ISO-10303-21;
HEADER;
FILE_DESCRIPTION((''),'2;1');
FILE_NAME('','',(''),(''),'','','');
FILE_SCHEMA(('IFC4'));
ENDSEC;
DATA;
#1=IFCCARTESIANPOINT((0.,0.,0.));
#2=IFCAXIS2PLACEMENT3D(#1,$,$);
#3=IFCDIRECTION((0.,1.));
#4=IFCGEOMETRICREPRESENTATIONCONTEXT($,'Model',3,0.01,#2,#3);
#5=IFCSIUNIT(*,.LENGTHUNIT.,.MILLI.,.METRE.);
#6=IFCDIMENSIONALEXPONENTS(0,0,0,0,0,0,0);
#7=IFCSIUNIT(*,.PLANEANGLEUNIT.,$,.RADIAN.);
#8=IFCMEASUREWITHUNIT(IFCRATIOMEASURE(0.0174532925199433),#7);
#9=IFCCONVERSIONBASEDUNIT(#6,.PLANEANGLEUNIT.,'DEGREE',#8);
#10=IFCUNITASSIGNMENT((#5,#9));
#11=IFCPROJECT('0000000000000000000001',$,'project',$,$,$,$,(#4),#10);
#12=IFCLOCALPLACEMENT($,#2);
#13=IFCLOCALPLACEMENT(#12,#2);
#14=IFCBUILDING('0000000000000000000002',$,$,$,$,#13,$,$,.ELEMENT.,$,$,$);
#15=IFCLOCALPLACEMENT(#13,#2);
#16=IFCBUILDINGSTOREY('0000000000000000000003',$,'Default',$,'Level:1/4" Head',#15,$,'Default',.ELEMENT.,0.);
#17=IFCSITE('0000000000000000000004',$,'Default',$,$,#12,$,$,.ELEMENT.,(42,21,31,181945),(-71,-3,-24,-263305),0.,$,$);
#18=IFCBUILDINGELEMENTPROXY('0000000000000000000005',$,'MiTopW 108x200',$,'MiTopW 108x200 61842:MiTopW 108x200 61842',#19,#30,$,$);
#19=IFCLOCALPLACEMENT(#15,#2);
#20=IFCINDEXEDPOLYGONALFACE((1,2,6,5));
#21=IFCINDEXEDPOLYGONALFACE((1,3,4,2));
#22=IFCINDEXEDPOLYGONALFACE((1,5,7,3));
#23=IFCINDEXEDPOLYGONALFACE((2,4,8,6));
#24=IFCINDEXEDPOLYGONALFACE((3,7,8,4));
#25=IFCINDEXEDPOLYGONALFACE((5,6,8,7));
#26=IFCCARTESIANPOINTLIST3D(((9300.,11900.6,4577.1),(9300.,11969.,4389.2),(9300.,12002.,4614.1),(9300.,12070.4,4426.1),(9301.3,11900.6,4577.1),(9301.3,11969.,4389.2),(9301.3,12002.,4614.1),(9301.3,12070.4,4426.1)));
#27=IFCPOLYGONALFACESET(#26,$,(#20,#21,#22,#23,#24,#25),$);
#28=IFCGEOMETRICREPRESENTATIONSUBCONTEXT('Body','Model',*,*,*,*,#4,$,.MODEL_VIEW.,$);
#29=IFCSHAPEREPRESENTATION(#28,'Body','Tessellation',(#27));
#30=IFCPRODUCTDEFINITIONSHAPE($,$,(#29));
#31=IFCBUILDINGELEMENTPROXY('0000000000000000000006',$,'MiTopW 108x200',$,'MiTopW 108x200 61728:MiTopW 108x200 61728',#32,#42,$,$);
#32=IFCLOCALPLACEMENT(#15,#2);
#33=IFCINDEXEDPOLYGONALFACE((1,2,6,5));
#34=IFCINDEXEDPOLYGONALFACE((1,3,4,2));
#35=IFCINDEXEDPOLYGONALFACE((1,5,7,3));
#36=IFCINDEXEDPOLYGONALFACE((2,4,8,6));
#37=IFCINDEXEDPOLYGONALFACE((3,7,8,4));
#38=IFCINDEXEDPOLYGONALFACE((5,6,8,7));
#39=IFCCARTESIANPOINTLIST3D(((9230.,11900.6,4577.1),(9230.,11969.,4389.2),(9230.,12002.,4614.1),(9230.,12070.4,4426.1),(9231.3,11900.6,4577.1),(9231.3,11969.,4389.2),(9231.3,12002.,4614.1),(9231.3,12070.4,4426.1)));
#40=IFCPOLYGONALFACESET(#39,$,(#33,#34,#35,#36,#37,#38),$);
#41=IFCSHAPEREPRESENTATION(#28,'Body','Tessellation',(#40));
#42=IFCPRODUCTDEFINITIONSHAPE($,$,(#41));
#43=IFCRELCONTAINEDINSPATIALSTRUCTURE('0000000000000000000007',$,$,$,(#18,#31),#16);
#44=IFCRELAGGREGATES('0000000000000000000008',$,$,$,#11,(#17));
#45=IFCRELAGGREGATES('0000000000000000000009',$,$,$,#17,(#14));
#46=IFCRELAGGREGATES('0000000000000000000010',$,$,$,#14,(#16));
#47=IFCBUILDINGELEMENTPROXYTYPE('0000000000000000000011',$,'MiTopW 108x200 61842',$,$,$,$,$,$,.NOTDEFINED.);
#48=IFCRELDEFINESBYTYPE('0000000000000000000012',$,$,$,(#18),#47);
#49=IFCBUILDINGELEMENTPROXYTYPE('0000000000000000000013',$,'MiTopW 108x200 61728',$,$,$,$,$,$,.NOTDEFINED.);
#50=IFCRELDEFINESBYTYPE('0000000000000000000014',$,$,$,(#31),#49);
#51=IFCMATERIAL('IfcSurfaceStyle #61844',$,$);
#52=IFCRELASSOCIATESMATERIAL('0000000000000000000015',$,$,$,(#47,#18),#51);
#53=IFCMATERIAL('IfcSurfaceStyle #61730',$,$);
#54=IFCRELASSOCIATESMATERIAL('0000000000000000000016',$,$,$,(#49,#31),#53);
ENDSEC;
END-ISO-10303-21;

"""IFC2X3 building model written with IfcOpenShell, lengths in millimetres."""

from ifc_helpers import new_model, entity, si_unit, converted_unit, direction, frame, origin, place, context, subcontext, project, spatial, polyline, outline, extrude, source, transform, mapped, material, type_object, type_shapes, element, save


model = new_model("IFC2X3")

# Units and contexts
model_context = context("Model", 3, precision=0.01, world=origin(), true_north=direction((0.0, 1.0)))
body_context = subcontext(model_context, "Body", "Model", "MODEL_VIEW")
ifc_project = project(units=[si_unit("LENGTHUNIT", "METRE", prefix="MILLI"), converted_unit("PLANEANGLEUNIT", "DEGREE", entity("IfcRatioMeasure", 0.0174532925199433), si_unit("PLANEANGLEUNIT", "RADIAN"), dimensions=[0, 0, 0, 0, 0, 0, 0])], contexts=[model_context])

# Site, building, storey
site_placement = place(None, origin())
site = spatial("IfcSite", under=ifc_project, at=site_placement, Name="Default", CompositionType="ELEMENT", RefLatitude=(42, 21, 31, 181945), RefLongitude=(-71, -3, -24, -263305), RefElevation=0.0)
building_placement = place(site_placement, origin())
building = spatial("IfcBuilding", under=site, at=building_placement, CompositionType="ELEMENT")
storey_placement = place(building_placement, origin())
storey = spatial("IfcBuildingStorey", under=building, at=storey_placement, Name="Default", ObjectType="Level:1/4\" Head", LongName="Default", CompositionType="ELEMENT", Elevation=0.0)

# Building element proxies
ifc_material_1 = material(Name="IfcSurfaceStyle #61844")
building_element_proxy_type_1 = type_object("IfcBuildingElementProxyType", Name="MiTopW 108x200 61842", PredefinedType="NOTDEFINED", material=ifc_material_1)
shared_shape_1 = source(origin(), body_context, "Body", "SweptSolid", [
    extrude(outline(polyline([(-54.0, -100.0), (54.0, -100.0), (54.0, 100.0), (-54.0, 100.0), (-54.0, -100.0)])), frame((100.0, 54.0, 0.0), z_axis=(0.0, 0.0, 1.0), x_axis=(-0.000002, 1.0, 0.0)), (0.0, 0.0, 1.0), 1.3),
])
type_shapes(building_element_proxy_type_1, [shared_shape_1])
proxy_1_placement = place(building_placement, frame((9301.3, 12002.0, 4614.1), z_axis=(-1.0, 0.0, 0.0), x_axis=(0.0, 0.34202, -0.939693)))
element("IfcBuildingElementProxy", 1, at=proxy_1_placement, inside=storey, type_object=building_element_proxy_type_1, material=ifc_material_1, Name="MiTopW 108x200", ObjectType="MiTopW 108x200 61842:MiTopW 108x200 61842", context=body_context, shape_type="MappedRepresentation", body=[
    mapped(shared_shape_1, transform((0.0, 0.0, 0.0), scale=1.0)),
])
ifc_material_2 = material(Name="IfcSurfaceStyle #61730")
building_element_proxy_type_2 = type_object("IfcBuildingElementProxyType", Name="MiTopW 108x200 61728", PredefinedType="NOTDEFINED", material=ifc_material_2)
shared_shape_2 = source(origin(), body_context, "Body", "SweptSolid", [
    extrude(outline(polyline([(-54.0, -100.0), (54.0, -100.0), (54.0, 100.0), (-54.0, 100.0), (-54.0, -100.0)])), frame((100.0, 54.0, 0.0), z_axis=(0.0, 0.0, 1.0), x_axis=(-0.000002, 1.0, 0.0)), (0.0, 0.0, 1.0), 1.3),
])
type_shapes(building_element_proxy_type_2, [shared_shape_2])
proxy_2_placement = place(building_placement, frame((9231.3, 12002.0, 4614.1), z_axis=(-1.0, 0.0, 0.0), x_axis=(0.0, 0.34202, -0.939693)))
element("IfcBuildingElementProxy", 2, at=proxy_2_placement, inside=storey, type_object=building_element_proxy_type_2, material=ifc_material_2, Name="MiTopW 108x200", ObjectType="MiTopW 108x200 61728:MiTopW 108x200 61728", context=body_context, shape_type="MappedRepresentation", body=[
    mapped(shared_shape_2, transform((0.0, 0.0, 0.0), scale=1.0)),
])

save(model, "model.ifc")
